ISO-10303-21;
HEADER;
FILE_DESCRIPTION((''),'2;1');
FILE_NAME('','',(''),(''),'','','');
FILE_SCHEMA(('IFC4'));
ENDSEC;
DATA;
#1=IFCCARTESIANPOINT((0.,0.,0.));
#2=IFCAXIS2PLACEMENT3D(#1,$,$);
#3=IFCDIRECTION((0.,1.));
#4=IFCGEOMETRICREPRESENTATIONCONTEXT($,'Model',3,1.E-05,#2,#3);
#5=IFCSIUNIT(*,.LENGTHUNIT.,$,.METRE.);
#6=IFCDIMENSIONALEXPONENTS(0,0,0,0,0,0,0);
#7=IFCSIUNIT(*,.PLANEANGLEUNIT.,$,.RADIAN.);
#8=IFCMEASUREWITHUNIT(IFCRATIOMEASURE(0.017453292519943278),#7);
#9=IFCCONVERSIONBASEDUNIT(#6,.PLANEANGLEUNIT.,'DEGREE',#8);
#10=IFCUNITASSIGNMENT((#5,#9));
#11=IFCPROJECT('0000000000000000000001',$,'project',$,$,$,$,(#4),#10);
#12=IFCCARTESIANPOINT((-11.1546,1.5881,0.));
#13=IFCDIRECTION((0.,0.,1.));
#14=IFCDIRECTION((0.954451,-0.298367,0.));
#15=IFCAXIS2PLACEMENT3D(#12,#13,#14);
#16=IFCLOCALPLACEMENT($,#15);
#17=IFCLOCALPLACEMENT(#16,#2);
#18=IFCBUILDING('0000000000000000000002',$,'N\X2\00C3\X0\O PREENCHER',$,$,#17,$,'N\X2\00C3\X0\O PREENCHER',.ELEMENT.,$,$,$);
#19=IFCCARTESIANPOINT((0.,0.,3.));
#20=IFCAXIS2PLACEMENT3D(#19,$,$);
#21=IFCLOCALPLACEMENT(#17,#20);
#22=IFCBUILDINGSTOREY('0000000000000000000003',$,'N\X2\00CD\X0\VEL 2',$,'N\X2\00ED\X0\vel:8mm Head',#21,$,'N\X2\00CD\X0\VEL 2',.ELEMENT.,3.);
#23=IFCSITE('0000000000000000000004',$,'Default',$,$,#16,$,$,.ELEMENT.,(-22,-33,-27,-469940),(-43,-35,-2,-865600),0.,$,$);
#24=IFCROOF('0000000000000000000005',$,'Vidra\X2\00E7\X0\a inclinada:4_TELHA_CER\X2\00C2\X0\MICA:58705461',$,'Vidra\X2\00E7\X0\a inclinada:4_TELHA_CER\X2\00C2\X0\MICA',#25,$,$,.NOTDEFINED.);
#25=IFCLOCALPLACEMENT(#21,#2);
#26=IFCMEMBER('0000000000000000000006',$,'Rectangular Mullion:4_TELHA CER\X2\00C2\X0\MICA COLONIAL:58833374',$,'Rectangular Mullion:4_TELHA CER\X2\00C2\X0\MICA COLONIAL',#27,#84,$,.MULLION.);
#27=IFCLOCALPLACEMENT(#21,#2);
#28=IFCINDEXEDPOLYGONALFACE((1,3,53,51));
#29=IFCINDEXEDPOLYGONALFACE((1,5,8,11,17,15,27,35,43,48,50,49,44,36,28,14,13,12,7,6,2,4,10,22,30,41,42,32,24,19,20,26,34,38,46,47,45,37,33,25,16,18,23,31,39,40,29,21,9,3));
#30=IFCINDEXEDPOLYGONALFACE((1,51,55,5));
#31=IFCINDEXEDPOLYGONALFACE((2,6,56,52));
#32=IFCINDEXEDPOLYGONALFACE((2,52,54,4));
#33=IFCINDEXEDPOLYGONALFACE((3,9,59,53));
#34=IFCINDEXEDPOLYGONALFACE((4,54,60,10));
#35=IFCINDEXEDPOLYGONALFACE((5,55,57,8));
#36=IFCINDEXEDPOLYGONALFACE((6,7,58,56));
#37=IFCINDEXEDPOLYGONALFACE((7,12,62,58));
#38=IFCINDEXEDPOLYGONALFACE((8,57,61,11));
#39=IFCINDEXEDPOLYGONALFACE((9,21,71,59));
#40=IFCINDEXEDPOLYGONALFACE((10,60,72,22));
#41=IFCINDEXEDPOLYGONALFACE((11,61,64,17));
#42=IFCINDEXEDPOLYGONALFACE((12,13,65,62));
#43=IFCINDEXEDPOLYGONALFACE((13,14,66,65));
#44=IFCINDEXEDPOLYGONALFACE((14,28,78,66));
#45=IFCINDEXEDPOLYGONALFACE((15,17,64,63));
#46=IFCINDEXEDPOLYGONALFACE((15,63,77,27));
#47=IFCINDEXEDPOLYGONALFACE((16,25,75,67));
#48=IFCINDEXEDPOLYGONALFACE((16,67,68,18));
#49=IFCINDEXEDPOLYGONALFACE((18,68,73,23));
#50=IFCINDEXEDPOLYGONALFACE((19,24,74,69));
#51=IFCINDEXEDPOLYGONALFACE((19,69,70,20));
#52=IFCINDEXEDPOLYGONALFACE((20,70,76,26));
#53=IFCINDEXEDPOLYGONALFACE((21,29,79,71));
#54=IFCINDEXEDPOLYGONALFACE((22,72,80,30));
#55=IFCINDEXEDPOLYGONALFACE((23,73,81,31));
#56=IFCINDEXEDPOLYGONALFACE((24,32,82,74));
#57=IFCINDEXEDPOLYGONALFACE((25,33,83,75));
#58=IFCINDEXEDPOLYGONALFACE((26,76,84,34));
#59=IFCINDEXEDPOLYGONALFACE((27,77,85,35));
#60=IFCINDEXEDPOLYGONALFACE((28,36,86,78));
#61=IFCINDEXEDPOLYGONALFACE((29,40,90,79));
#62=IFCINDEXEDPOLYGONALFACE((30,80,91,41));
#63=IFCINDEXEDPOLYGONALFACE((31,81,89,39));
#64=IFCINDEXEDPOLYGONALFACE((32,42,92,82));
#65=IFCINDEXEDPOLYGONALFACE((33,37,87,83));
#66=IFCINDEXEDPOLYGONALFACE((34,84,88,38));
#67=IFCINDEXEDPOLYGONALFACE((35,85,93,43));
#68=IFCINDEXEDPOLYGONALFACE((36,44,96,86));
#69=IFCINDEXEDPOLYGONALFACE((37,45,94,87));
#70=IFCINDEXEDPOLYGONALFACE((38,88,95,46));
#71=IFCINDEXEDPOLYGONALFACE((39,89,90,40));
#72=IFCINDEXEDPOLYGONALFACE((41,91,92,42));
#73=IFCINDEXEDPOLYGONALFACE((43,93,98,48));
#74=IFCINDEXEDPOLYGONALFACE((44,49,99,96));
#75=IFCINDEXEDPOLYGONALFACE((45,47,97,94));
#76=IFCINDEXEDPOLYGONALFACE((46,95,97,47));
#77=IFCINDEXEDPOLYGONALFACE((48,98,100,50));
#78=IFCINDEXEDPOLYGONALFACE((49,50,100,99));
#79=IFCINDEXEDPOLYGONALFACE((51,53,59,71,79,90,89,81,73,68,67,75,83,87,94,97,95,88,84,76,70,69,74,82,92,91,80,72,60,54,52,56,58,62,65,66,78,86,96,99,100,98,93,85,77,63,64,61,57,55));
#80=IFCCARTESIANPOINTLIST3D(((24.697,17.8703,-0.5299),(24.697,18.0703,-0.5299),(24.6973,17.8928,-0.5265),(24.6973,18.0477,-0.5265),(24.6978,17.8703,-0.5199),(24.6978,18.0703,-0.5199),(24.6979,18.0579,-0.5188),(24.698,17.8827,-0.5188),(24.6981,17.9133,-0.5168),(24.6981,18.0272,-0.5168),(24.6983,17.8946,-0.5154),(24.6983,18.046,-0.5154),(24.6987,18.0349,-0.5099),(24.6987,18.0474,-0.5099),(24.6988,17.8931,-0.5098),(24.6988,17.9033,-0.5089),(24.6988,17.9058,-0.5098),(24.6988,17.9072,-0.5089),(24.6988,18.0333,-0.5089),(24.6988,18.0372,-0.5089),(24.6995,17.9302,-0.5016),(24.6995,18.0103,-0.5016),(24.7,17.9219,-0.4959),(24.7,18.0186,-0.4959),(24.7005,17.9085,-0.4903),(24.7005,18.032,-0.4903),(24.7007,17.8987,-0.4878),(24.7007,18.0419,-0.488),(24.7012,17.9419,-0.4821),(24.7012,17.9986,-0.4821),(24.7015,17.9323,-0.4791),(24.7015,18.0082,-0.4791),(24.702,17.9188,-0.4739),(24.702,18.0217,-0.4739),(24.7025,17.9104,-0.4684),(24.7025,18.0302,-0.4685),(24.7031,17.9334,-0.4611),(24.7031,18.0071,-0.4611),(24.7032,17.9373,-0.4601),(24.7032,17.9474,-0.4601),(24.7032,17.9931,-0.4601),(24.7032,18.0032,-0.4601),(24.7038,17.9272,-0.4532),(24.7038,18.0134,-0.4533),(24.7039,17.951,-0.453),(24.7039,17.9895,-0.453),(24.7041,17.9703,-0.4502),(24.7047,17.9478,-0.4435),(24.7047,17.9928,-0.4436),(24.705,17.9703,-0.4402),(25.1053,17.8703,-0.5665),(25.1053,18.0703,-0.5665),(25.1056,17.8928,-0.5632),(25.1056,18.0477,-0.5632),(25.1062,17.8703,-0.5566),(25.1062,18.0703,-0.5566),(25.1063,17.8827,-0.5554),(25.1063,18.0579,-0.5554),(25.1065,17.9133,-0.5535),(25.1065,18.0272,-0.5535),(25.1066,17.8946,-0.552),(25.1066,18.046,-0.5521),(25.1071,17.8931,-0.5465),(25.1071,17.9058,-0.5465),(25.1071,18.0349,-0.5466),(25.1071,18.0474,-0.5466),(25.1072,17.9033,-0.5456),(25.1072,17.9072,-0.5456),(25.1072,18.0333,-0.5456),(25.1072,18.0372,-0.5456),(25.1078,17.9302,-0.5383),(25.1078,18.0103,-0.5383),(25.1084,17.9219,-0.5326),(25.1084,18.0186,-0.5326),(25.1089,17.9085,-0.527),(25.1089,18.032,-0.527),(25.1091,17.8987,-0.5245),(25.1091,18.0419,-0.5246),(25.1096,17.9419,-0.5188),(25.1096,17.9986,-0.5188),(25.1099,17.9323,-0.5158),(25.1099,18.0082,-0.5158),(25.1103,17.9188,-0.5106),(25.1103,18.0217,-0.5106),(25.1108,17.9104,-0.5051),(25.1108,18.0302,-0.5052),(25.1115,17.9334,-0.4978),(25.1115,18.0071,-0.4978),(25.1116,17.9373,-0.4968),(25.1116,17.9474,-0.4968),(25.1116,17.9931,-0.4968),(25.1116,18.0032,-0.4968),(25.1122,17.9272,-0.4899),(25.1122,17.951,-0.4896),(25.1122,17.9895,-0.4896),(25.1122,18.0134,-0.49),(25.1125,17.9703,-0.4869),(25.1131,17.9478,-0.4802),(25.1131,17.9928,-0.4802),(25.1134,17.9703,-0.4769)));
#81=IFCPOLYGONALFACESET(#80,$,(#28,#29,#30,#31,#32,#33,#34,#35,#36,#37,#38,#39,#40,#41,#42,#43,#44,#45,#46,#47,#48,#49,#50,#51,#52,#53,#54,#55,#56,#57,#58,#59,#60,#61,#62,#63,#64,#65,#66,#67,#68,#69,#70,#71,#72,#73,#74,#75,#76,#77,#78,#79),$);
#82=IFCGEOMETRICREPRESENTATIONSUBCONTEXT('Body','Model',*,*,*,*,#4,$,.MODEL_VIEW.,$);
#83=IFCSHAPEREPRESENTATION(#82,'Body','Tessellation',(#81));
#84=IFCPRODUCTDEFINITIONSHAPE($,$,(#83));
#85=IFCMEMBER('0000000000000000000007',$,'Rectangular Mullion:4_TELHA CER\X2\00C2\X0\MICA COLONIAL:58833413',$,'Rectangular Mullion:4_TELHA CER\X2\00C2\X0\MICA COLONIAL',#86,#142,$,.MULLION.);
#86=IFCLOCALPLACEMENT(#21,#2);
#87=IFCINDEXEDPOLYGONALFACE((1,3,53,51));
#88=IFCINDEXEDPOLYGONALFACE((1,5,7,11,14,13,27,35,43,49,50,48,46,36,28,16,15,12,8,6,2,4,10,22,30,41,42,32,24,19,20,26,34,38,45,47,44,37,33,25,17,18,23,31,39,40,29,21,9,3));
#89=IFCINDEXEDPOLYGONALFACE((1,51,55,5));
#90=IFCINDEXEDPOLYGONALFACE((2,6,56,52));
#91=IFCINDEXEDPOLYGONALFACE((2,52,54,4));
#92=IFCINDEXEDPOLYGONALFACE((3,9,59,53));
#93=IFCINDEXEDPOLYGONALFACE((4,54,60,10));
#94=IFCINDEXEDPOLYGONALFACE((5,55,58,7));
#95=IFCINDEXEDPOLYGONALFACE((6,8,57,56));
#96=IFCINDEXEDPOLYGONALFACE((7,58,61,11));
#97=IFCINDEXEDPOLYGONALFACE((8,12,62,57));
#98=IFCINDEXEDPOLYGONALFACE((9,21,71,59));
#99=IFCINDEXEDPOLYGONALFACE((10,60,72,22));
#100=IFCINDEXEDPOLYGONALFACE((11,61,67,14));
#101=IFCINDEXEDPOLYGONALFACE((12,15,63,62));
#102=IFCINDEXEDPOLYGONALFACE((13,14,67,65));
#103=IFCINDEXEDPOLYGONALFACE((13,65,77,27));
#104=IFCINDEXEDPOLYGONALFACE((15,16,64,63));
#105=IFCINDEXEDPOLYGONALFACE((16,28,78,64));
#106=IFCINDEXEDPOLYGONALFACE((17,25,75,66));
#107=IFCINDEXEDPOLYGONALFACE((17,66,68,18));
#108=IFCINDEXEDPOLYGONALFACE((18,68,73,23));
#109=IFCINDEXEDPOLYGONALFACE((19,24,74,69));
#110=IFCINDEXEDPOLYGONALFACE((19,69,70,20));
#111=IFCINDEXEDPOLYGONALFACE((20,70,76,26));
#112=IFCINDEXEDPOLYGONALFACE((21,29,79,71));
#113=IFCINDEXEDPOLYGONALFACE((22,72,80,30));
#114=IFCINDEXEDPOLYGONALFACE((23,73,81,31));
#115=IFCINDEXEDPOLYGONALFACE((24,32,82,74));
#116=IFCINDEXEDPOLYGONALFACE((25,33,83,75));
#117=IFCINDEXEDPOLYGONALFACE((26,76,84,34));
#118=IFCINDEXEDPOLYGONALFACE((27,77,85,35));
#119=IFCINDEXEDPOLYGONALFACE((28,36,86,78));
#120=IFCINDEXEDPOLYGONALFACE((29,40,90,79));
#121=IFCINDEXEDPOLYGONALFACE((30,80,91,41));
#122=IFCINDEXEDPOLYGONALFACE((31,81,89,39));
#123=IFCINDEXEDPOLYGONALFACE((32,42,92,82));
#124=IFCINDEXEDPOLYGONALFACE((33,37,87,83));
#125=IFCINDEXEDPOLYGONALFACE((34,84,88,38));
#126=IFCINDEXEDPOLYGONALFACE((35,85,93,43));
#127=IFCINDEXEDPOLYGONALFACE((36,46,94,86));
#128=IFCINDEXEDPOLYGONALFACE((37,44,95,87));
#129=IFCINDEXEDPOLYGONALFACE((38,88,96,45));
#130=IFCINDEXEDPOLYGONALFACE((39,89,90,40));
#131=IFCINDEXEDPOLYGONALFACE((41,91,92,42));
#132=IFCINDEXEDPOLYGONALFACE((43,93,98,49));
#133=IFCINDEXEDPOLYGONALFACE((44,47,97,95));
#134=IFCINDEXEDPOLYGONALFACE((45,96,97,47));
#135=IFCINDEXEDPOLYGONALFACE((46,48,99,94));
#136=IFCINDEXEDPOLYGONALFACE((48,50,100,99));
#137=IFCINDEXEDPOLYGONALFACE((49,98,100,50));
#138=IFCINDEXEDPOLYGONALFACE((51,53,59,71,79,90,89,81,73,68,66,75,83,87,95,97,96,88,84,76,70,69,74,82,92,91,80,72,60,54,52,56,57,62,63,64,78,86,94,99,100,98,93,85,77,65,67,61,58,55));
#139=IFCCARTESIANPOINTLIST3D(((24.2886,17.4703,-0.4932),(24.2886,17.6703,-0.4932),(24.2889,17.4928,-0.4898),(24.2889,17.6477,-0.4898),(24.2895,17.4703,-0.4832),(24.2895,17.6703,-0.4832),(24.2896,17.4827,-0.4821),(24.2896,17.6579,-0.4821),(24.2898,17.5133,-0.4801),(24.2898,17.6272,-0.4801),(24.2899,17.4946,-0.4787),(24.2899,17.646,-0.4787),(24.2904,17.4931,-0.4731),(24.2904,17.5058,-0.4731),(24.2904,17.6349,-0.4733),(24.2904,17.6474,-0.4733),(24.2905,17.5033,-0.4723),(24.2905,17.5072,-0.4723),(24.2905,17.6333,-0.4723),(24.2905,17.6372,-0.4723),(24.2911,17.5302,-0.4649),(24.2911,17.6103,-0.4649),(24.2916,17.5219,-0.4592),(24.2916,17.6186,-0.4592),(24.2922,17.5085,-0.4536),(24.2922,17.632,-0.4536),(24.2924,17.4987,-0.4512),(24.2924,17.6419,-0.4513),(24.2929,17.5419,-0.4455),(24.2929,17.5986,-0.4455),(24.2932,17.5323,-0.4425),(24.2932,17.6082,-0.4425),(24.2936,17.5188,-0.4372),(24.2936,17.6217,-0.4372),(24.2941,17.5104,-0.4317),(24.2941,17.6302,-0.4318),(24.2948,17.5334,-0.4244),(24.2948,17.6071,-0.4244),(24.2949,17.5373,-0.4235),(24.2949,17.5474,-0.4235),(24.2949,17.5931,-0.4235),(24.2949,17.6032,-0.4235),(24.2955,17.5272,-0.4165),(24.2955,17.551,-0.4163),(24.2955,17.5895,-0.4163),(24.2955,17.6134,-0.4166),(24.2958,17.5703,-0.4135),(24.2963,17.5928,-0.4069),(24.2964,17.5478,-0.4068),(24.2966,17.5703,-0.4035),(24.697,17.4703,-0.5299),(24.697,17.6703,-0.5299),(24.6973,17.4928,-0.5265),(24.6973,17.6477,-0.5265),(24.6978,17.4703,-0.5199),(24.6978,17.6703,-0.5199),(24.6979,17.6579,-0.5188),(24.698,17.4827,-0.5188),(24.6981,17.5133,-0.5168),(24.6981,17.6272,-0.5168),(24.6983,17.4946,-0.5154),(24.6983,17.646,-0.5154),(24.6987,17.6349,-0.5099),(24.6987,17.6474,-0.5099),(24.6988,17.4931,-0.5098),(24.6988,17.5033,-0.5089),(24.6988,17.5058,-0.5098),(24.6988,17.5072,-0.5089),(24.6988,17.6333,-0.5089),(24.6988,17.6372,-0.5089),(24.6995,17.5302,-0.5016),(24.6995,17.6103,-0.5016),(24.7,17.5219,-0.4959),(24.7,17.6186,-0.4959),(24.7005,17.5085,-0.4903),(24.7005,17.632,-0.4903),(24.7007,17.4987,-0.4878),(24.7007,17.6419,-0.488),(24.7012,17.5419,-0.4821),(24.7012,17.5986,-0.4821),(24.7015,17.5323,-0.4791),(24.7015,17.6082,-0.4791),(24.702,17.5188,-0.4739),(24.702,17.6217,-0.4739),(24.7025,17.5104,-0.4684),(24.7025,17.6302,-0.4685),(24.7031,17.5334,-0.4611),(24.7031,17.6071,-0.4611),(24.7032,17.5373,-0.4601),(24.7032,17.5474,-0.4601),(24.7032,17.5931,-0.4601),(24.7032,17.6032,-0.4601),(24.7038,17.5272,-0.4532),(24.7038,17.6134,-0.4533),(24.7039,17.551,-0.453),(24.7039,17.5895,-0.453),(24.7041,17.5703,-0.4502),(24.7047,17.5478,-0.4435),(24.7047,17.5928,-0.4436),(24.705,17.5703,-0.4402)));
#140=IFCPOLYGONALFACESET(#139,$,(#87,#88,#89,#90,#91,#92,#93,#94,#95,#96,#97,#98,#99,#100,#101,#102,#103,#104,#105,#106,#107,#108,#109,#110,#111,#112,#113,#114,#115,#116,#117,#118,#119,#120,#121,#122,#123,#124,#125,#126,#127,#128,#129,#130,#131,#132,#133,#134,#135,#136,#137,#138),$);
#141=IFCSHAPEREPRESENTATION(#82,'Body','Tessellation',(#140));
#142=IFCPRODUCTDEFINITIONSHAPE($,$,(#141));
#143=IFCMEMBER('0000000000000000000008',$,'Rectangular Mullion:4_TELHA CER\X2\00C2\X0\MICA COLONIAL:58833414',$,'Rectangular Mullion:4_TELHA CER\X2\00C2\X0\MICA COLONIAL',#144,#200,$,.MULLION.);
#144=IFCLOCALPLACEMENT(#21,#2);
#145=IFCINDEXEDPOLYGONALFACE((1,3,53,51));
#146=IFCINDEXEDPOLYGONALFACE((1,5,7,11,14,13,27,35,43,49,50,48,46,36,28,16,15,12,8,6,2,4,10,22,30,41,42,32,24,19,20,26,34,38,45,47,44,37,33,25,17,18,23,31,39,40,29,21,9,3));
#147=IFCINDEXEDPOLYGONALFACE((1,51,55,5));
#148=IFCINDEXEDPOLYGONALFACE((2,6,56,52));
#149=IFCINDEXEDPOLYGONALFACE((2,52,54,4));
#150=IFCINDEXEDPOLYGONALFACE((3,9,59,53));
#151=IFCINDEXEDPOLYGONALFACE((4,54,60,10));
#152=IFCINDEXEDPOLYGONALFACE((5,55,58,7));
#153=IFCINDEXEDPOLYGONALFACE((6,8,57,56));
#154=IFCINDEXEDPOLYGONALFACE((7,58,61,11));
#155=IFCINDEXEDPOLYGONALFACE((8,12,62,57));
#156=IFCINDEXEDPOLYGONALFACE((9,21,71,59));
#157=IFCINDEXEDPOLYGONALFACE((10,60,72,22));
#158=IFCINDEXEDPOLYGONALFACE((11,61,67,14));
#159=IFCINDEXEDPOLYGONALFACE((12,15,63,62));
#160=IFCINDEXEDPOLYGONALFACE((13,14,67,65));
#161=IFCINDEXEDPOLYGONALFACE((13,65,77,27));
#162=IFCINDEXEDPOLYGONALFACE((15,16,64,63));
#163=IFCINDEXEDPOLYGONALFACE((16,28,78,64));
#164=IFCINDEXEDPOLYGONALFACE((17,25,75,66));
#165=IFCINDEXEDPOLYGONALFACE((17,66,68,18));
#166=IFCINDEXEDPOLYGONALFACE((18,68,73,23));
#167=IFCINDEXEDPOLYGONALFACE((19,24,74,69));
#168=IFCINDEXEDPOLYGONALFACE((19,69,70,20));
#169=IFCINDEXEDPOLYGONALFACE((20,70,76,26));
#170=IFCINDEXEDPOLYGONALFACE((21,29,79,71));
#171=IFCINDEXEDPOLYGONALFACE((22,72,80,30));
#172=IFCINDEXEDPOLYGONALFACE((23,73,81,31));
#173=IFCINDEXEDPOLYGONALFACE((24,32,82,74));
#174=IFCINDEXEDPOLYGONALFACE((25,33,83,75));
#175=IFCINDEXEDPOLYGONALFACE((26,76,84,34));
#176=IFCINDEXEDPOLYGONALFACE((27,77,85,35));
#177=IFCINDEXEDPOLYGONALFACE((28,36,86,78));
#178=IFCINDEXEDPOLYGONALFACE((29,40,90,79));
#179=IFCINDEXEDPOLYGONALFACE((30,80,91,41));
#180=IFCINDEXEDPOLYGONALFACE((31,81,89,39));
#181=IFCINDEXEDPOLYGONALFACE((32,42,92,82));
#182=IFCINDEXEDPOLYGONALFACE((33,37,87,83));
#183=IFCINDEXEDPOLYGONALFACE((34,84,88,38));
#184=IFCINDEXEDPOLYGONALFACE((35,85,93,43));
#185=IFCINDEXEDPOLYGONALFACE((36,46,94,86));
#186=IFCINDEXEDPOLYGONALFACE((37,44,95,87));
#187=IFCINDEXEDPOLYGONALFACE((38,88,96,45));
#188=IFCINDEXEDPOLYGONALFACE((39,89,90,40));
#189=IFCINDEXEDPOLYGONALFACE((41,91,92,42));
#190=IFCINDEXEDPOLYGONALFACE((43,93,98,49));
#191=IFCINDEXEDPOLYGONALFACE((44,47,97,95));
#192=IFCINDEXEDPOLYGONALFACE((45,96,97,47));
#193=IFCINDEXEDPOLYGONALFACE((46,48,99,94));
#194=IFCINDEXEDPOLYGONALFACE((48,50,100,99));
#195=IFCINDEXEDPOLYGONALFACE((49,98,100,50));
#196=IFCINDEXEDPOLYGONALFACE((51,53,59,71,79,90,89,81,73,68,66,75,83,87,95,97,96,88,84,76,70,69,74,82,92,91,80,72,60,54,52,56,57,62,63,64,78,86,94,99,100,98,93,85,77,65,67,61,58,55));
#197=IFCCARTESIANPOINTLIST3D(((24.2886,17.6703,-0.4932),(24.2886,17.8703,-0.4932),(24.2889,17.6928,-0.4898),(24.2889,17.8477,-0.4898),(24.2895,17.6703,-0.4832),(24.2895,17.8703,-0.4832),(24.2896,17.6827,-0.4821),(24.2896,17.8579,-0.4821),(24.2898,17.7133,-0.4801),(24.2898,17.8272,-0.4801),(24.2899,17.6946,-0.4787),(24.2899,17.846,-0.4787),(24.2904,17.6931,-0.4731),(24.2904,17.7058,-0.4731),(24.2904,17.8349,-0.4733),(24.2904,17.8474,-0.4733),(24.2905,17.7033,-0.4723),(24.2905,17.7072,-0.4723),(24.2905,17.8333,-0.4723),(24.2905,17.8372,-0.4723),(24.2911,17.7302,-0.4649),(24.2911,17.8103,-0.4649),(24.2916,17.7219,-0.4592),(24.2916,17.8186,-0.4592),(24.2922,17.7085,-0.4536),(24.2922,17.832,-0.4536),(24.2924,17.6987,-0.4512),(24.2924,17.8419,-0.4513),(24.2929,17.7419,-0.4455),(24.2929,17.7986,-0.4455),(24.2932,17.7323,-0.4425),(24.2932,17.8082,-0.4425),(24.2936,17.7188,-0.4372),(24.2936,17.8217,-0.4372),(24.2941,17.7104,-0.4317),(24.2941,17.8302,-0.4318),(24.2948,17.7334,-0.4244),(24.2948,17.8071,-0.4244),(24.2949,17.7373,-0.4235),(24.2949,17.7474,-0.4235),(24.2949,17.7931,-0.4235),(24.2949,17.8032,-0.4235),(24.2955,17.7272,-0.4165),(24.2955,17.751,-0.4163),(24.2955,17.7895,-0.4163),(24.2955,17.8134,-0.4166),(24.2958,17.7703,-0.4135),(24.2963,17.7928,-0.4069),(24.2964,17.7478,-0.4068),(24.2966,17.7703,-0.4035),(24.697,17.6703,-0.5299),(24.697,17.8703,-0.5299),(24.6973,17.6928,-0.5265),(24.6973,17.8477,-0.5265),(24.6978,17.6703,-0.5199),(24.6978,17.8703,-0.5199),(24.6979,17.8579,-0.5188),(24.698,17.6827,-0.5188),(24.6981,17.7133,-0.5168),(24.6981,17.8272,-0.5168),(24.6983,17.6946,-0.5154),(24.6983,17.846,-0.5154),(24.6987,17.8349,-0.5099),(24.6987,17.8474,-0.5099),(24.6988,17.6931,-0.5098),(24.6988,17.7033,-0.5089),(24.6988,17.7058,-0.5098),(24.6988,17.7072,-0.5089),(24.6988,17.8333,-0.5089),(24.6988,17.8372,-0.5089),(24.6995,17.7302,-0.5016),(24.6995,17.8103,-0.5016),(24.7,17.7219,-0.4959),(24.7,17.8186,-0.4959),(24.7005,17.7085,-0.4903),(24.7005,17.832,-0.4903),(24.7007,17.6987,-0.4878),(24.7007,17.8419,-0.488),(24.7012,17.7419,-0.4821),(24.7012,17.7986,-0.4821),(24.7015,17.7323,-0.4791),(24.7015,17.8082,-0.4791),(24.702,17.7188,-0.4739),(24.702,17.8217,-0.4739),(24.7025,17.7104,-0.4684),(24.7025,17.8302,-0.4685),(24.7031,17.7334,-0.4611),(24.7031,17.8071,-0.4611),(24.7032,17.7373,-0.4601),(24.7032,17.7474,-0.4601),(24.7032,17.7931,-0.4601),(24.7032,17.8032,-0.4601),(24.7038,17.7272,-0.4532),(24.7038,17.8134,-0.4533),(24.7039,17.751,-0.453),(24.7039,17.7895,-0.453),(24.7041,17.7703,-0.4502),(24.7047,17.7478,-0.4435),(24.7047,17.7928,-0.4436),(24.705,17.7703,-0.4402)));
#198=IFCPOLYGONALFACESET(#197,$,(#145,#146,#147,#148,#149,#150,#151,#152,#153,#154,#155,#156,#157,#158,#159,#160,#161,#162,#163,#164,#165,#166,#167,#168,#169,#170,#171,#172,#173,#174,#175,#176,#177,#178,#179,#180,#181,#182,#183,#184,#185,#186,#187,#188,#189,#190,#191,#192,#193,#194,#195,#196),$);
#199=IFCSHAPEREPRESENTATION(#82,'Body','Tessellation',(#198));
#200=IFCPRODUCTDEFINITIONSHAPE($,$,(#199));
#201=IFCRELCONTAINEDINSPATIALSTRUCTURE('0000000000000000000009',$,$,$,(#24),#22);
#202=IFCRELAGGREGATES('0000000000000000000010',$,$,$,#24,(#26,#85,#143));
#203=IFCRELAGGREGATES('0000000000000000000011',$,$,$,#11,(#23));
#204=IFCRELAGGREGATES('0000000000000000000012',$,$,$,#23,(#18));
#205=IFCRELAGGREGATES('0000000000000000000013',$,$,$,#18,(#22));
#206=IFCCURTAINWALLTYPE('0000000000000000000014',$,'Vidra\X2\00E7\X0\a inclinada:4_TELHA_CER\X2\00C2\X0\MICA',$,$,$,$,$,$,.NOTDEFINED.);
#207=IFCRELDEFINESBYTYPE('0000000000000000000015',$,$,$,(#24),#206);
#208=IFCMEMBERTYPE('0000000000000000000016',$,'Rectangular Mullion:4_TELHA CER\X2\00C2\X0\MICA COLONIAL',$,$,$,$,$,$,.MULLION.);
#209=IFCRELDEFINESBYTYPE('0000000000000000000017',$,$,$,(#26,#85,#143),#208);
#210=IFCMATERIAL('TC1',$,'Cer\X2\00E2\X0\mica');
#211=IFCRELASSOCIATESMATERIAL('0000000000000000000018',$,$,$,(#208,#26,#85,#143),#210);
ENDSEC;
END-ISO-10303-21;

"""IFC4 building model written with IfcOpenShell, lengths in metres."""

from ifc_helpers import new_model, entity, si_unit, converted_unit, direction, frame, origin, place, context, subcontext, project, spatial, line, arc, indexed_curve, outline, extrude, source, transform, mapped, material, type_object, type_shapes, element, aggregate, save


model = new_model("IFC4")

# Units and contexts
model_context = context("Model", 3, precision=1e-05, world=origin(), true_north=direction((0.0, 1.0)))
body_context = subcontext(model_context, "Body", "Model", "MODEL_VIEW")
ifc_project = project(units=[si_unit("LENGTHUNIT", "METRE"), converted_unit("PLANEANGLEUNIT", "DEGREE", entity("IfcRatioMeasure", 0.017453292519943278), si_unit("PLANEANGLEUNIT", "RADIAN"), dimensions=[0, 0, 0, 0, 0, 0, 0])], contexts=[model_context])

# Site, building, storey
site_placement = place(None, frame((-11.1546, 1.5881, 0.0), z_axis=(0.0, 0.0, 1.0), x_axis=(0.954451, -0.298367, 0.0)))
site = spatial("IfcSite", under=ifc_project, at=site_placement, Name="Default", CompositionType="ELEMENT", RefLatitude=(-22, -33, -27, -469940), RefLongitude=(-43, -35, -2, -865600), RefElevation=0.0)
building_placement = place(site_placement, origin())
building = spatial("IfcBuilding", under=site, at=building_placement, Name="NÃO PREENCHER", LongName="NÃO PREENCHER", CompositionType="ELEMENT")
storey_placement = place(building_placement, frame((0.0, 0.0, 3.0)))
storey = spatial("IfcBuildingStorey", under=building, at=storey_placement, Name="NÍVEL 2", ObjectType="Nível:8mm Head", LongName="NÍVEL 2", CompositionType="ELEMENT", Elevation=3.0)

# Roof, members
curtain_wall_type = type_object("IfcCurtainWallType", Name="Vidraça inclinada:4_TELHA_CERÂMICA", PredefinedType="NOTDEFINED")
roof_placement = place(storey_placement, frame((0.0, 0.0, -3.0)))
roof = element("IfcRoof", 1, at=roof_placement, inside=storey, type_object=curtain_wall_type, Name="Vidraça inclinada:4_TELHA_CERÂMICA:58705461", ObjectType="Vidraça inclinada:4_TELHA_CERÂMICA", PredefinedType="NOTDEFINED")
ifc_material = material(Name="TC1", Category="Cerâmica")
member_type = type_object("IfcMemberType", Name="Rectangular Mullion:4_TELHA CERÂMICA COLONIAL", PredefinedType="MULLION", material=ifc_material)
shared_shape = source(origin(), body_context, "Body", "SweptSolid", [
    extrude(outline(indexed_curve([(-0.029, -0.1), (-0.019, -0.1), (-0.0164, -0.0815), (-0.0089, -0.0645), (-0.0089, -0.0771), (0.061, 0.0), (-0.009, 0.0771), (-0.009, 0.0646), (-0.0165, 0.0816), (-0.019, 0.1), (-0.029, 0.1), (-0.0089, 0.0479), (0.041, 0.0229), (0.041, 0.0329), (0.0131, 0.0425), (-0.008, 0.0631), (-0.008, 0.067), (0.051, 0.0), (-0.008, -0.067), (-0.008, -0.0631), (0.0131, -0.0425), (0.041, -0.0329), (0.041, -0.0229), (-0.0089, -0.0479)], segments=[line(1, 2), arc(2, 3, 4), line(4, 5), arc(5, 6, 7), line(7, 8), arc(8, 9, 10), line(10, 11), arc(11, 12, 13), line(13, 14), arc(14, 15, 16), line(16, 17), arc(17, 18, 19), line(19, 20), arc(20, 21, 22), line(22, 23), arc(23, 24, 1)], self_intersect=False)), frame((0.0, -0.029, -0.41), z_axis=(0.0, 0.0, 1.0), x_axis=(0.0, -1.0, 0.0)), (0.0, 0.0, 1.0), 0.41),
])
type_shapes(member_type, [shared_shape])
member_1_placement = place(roof_placement, frame((24.697, 17.9703, 2.4701), z_axis=(-0.99599, 0.0, 0.089469), x_axis=(0.0, 1.0, 0.0)))
member_1 = element("IfcMember", 2, at=member_1_placement, type_object=member_type, material=ifc_material, Name="Rectangular Mullion:4_TELHA CERÂMICA COLONIAL:58833374", ObjectType="Rectangular Mullion:4_TELHA CERÂMICA COLONIAL", PredefinedType="MULLION", context=body_context, shape_type="MappedRepresentation", body=[
    mapped(shared_shape, transform((0.0, 0.0, 0.0), scale=1.0)),
])
member_2_placement = place(roof_placement, frame((24.2886, 17.5703, 2.5068), z_axis=(-0.99599, 0.0, 0.089469), x_axis=(0.0, 1.0, 0.0)))
member_2 = element("IfcMember", 3, at=member_2_placement, type_object=member_type, material=ifc_material, Name="Rectangular Mullion:4_TELHA CERÂMICA COLONIAL:58833413", ObjectType="Rectangular Mullion:4_TELHA CERÂMICA COLONIAL", PredefinedType="MULLION", context=body_context, shape_type="MappedRepresentation", body=[
    mapped(shared_shape, transform((0.0, 0.0, 0.0), scale=1.0)),
])
member_3_placement = place(roof_placement, frame((24.2886, 17.7703, 2.5068), z_axis=(-0.99599, 0.0, 0.089469), x_axis=(0.0, 1.0, 0.0)))
member_3 = element("IfcMember", 4, at=member_3_placement, type_object=member_type, material=ifc_material, Name="Rectangular Mullion:4_TELHA CERÂMICA COLONIAL:58833414", ObjectType="Rectangular Mullion:4_TELHA CERÂMICA COLONIAL", PredefinedType="MULLION", context=body_context, shape_type="MappedRepresentation", body=[
    mapped(shared_shape, transform((0.0, 0.0, 0.0), scale=1.0)),
])
aggregate(roof, [member_1, member_2, member_3])

save(model, "model.ifc")
